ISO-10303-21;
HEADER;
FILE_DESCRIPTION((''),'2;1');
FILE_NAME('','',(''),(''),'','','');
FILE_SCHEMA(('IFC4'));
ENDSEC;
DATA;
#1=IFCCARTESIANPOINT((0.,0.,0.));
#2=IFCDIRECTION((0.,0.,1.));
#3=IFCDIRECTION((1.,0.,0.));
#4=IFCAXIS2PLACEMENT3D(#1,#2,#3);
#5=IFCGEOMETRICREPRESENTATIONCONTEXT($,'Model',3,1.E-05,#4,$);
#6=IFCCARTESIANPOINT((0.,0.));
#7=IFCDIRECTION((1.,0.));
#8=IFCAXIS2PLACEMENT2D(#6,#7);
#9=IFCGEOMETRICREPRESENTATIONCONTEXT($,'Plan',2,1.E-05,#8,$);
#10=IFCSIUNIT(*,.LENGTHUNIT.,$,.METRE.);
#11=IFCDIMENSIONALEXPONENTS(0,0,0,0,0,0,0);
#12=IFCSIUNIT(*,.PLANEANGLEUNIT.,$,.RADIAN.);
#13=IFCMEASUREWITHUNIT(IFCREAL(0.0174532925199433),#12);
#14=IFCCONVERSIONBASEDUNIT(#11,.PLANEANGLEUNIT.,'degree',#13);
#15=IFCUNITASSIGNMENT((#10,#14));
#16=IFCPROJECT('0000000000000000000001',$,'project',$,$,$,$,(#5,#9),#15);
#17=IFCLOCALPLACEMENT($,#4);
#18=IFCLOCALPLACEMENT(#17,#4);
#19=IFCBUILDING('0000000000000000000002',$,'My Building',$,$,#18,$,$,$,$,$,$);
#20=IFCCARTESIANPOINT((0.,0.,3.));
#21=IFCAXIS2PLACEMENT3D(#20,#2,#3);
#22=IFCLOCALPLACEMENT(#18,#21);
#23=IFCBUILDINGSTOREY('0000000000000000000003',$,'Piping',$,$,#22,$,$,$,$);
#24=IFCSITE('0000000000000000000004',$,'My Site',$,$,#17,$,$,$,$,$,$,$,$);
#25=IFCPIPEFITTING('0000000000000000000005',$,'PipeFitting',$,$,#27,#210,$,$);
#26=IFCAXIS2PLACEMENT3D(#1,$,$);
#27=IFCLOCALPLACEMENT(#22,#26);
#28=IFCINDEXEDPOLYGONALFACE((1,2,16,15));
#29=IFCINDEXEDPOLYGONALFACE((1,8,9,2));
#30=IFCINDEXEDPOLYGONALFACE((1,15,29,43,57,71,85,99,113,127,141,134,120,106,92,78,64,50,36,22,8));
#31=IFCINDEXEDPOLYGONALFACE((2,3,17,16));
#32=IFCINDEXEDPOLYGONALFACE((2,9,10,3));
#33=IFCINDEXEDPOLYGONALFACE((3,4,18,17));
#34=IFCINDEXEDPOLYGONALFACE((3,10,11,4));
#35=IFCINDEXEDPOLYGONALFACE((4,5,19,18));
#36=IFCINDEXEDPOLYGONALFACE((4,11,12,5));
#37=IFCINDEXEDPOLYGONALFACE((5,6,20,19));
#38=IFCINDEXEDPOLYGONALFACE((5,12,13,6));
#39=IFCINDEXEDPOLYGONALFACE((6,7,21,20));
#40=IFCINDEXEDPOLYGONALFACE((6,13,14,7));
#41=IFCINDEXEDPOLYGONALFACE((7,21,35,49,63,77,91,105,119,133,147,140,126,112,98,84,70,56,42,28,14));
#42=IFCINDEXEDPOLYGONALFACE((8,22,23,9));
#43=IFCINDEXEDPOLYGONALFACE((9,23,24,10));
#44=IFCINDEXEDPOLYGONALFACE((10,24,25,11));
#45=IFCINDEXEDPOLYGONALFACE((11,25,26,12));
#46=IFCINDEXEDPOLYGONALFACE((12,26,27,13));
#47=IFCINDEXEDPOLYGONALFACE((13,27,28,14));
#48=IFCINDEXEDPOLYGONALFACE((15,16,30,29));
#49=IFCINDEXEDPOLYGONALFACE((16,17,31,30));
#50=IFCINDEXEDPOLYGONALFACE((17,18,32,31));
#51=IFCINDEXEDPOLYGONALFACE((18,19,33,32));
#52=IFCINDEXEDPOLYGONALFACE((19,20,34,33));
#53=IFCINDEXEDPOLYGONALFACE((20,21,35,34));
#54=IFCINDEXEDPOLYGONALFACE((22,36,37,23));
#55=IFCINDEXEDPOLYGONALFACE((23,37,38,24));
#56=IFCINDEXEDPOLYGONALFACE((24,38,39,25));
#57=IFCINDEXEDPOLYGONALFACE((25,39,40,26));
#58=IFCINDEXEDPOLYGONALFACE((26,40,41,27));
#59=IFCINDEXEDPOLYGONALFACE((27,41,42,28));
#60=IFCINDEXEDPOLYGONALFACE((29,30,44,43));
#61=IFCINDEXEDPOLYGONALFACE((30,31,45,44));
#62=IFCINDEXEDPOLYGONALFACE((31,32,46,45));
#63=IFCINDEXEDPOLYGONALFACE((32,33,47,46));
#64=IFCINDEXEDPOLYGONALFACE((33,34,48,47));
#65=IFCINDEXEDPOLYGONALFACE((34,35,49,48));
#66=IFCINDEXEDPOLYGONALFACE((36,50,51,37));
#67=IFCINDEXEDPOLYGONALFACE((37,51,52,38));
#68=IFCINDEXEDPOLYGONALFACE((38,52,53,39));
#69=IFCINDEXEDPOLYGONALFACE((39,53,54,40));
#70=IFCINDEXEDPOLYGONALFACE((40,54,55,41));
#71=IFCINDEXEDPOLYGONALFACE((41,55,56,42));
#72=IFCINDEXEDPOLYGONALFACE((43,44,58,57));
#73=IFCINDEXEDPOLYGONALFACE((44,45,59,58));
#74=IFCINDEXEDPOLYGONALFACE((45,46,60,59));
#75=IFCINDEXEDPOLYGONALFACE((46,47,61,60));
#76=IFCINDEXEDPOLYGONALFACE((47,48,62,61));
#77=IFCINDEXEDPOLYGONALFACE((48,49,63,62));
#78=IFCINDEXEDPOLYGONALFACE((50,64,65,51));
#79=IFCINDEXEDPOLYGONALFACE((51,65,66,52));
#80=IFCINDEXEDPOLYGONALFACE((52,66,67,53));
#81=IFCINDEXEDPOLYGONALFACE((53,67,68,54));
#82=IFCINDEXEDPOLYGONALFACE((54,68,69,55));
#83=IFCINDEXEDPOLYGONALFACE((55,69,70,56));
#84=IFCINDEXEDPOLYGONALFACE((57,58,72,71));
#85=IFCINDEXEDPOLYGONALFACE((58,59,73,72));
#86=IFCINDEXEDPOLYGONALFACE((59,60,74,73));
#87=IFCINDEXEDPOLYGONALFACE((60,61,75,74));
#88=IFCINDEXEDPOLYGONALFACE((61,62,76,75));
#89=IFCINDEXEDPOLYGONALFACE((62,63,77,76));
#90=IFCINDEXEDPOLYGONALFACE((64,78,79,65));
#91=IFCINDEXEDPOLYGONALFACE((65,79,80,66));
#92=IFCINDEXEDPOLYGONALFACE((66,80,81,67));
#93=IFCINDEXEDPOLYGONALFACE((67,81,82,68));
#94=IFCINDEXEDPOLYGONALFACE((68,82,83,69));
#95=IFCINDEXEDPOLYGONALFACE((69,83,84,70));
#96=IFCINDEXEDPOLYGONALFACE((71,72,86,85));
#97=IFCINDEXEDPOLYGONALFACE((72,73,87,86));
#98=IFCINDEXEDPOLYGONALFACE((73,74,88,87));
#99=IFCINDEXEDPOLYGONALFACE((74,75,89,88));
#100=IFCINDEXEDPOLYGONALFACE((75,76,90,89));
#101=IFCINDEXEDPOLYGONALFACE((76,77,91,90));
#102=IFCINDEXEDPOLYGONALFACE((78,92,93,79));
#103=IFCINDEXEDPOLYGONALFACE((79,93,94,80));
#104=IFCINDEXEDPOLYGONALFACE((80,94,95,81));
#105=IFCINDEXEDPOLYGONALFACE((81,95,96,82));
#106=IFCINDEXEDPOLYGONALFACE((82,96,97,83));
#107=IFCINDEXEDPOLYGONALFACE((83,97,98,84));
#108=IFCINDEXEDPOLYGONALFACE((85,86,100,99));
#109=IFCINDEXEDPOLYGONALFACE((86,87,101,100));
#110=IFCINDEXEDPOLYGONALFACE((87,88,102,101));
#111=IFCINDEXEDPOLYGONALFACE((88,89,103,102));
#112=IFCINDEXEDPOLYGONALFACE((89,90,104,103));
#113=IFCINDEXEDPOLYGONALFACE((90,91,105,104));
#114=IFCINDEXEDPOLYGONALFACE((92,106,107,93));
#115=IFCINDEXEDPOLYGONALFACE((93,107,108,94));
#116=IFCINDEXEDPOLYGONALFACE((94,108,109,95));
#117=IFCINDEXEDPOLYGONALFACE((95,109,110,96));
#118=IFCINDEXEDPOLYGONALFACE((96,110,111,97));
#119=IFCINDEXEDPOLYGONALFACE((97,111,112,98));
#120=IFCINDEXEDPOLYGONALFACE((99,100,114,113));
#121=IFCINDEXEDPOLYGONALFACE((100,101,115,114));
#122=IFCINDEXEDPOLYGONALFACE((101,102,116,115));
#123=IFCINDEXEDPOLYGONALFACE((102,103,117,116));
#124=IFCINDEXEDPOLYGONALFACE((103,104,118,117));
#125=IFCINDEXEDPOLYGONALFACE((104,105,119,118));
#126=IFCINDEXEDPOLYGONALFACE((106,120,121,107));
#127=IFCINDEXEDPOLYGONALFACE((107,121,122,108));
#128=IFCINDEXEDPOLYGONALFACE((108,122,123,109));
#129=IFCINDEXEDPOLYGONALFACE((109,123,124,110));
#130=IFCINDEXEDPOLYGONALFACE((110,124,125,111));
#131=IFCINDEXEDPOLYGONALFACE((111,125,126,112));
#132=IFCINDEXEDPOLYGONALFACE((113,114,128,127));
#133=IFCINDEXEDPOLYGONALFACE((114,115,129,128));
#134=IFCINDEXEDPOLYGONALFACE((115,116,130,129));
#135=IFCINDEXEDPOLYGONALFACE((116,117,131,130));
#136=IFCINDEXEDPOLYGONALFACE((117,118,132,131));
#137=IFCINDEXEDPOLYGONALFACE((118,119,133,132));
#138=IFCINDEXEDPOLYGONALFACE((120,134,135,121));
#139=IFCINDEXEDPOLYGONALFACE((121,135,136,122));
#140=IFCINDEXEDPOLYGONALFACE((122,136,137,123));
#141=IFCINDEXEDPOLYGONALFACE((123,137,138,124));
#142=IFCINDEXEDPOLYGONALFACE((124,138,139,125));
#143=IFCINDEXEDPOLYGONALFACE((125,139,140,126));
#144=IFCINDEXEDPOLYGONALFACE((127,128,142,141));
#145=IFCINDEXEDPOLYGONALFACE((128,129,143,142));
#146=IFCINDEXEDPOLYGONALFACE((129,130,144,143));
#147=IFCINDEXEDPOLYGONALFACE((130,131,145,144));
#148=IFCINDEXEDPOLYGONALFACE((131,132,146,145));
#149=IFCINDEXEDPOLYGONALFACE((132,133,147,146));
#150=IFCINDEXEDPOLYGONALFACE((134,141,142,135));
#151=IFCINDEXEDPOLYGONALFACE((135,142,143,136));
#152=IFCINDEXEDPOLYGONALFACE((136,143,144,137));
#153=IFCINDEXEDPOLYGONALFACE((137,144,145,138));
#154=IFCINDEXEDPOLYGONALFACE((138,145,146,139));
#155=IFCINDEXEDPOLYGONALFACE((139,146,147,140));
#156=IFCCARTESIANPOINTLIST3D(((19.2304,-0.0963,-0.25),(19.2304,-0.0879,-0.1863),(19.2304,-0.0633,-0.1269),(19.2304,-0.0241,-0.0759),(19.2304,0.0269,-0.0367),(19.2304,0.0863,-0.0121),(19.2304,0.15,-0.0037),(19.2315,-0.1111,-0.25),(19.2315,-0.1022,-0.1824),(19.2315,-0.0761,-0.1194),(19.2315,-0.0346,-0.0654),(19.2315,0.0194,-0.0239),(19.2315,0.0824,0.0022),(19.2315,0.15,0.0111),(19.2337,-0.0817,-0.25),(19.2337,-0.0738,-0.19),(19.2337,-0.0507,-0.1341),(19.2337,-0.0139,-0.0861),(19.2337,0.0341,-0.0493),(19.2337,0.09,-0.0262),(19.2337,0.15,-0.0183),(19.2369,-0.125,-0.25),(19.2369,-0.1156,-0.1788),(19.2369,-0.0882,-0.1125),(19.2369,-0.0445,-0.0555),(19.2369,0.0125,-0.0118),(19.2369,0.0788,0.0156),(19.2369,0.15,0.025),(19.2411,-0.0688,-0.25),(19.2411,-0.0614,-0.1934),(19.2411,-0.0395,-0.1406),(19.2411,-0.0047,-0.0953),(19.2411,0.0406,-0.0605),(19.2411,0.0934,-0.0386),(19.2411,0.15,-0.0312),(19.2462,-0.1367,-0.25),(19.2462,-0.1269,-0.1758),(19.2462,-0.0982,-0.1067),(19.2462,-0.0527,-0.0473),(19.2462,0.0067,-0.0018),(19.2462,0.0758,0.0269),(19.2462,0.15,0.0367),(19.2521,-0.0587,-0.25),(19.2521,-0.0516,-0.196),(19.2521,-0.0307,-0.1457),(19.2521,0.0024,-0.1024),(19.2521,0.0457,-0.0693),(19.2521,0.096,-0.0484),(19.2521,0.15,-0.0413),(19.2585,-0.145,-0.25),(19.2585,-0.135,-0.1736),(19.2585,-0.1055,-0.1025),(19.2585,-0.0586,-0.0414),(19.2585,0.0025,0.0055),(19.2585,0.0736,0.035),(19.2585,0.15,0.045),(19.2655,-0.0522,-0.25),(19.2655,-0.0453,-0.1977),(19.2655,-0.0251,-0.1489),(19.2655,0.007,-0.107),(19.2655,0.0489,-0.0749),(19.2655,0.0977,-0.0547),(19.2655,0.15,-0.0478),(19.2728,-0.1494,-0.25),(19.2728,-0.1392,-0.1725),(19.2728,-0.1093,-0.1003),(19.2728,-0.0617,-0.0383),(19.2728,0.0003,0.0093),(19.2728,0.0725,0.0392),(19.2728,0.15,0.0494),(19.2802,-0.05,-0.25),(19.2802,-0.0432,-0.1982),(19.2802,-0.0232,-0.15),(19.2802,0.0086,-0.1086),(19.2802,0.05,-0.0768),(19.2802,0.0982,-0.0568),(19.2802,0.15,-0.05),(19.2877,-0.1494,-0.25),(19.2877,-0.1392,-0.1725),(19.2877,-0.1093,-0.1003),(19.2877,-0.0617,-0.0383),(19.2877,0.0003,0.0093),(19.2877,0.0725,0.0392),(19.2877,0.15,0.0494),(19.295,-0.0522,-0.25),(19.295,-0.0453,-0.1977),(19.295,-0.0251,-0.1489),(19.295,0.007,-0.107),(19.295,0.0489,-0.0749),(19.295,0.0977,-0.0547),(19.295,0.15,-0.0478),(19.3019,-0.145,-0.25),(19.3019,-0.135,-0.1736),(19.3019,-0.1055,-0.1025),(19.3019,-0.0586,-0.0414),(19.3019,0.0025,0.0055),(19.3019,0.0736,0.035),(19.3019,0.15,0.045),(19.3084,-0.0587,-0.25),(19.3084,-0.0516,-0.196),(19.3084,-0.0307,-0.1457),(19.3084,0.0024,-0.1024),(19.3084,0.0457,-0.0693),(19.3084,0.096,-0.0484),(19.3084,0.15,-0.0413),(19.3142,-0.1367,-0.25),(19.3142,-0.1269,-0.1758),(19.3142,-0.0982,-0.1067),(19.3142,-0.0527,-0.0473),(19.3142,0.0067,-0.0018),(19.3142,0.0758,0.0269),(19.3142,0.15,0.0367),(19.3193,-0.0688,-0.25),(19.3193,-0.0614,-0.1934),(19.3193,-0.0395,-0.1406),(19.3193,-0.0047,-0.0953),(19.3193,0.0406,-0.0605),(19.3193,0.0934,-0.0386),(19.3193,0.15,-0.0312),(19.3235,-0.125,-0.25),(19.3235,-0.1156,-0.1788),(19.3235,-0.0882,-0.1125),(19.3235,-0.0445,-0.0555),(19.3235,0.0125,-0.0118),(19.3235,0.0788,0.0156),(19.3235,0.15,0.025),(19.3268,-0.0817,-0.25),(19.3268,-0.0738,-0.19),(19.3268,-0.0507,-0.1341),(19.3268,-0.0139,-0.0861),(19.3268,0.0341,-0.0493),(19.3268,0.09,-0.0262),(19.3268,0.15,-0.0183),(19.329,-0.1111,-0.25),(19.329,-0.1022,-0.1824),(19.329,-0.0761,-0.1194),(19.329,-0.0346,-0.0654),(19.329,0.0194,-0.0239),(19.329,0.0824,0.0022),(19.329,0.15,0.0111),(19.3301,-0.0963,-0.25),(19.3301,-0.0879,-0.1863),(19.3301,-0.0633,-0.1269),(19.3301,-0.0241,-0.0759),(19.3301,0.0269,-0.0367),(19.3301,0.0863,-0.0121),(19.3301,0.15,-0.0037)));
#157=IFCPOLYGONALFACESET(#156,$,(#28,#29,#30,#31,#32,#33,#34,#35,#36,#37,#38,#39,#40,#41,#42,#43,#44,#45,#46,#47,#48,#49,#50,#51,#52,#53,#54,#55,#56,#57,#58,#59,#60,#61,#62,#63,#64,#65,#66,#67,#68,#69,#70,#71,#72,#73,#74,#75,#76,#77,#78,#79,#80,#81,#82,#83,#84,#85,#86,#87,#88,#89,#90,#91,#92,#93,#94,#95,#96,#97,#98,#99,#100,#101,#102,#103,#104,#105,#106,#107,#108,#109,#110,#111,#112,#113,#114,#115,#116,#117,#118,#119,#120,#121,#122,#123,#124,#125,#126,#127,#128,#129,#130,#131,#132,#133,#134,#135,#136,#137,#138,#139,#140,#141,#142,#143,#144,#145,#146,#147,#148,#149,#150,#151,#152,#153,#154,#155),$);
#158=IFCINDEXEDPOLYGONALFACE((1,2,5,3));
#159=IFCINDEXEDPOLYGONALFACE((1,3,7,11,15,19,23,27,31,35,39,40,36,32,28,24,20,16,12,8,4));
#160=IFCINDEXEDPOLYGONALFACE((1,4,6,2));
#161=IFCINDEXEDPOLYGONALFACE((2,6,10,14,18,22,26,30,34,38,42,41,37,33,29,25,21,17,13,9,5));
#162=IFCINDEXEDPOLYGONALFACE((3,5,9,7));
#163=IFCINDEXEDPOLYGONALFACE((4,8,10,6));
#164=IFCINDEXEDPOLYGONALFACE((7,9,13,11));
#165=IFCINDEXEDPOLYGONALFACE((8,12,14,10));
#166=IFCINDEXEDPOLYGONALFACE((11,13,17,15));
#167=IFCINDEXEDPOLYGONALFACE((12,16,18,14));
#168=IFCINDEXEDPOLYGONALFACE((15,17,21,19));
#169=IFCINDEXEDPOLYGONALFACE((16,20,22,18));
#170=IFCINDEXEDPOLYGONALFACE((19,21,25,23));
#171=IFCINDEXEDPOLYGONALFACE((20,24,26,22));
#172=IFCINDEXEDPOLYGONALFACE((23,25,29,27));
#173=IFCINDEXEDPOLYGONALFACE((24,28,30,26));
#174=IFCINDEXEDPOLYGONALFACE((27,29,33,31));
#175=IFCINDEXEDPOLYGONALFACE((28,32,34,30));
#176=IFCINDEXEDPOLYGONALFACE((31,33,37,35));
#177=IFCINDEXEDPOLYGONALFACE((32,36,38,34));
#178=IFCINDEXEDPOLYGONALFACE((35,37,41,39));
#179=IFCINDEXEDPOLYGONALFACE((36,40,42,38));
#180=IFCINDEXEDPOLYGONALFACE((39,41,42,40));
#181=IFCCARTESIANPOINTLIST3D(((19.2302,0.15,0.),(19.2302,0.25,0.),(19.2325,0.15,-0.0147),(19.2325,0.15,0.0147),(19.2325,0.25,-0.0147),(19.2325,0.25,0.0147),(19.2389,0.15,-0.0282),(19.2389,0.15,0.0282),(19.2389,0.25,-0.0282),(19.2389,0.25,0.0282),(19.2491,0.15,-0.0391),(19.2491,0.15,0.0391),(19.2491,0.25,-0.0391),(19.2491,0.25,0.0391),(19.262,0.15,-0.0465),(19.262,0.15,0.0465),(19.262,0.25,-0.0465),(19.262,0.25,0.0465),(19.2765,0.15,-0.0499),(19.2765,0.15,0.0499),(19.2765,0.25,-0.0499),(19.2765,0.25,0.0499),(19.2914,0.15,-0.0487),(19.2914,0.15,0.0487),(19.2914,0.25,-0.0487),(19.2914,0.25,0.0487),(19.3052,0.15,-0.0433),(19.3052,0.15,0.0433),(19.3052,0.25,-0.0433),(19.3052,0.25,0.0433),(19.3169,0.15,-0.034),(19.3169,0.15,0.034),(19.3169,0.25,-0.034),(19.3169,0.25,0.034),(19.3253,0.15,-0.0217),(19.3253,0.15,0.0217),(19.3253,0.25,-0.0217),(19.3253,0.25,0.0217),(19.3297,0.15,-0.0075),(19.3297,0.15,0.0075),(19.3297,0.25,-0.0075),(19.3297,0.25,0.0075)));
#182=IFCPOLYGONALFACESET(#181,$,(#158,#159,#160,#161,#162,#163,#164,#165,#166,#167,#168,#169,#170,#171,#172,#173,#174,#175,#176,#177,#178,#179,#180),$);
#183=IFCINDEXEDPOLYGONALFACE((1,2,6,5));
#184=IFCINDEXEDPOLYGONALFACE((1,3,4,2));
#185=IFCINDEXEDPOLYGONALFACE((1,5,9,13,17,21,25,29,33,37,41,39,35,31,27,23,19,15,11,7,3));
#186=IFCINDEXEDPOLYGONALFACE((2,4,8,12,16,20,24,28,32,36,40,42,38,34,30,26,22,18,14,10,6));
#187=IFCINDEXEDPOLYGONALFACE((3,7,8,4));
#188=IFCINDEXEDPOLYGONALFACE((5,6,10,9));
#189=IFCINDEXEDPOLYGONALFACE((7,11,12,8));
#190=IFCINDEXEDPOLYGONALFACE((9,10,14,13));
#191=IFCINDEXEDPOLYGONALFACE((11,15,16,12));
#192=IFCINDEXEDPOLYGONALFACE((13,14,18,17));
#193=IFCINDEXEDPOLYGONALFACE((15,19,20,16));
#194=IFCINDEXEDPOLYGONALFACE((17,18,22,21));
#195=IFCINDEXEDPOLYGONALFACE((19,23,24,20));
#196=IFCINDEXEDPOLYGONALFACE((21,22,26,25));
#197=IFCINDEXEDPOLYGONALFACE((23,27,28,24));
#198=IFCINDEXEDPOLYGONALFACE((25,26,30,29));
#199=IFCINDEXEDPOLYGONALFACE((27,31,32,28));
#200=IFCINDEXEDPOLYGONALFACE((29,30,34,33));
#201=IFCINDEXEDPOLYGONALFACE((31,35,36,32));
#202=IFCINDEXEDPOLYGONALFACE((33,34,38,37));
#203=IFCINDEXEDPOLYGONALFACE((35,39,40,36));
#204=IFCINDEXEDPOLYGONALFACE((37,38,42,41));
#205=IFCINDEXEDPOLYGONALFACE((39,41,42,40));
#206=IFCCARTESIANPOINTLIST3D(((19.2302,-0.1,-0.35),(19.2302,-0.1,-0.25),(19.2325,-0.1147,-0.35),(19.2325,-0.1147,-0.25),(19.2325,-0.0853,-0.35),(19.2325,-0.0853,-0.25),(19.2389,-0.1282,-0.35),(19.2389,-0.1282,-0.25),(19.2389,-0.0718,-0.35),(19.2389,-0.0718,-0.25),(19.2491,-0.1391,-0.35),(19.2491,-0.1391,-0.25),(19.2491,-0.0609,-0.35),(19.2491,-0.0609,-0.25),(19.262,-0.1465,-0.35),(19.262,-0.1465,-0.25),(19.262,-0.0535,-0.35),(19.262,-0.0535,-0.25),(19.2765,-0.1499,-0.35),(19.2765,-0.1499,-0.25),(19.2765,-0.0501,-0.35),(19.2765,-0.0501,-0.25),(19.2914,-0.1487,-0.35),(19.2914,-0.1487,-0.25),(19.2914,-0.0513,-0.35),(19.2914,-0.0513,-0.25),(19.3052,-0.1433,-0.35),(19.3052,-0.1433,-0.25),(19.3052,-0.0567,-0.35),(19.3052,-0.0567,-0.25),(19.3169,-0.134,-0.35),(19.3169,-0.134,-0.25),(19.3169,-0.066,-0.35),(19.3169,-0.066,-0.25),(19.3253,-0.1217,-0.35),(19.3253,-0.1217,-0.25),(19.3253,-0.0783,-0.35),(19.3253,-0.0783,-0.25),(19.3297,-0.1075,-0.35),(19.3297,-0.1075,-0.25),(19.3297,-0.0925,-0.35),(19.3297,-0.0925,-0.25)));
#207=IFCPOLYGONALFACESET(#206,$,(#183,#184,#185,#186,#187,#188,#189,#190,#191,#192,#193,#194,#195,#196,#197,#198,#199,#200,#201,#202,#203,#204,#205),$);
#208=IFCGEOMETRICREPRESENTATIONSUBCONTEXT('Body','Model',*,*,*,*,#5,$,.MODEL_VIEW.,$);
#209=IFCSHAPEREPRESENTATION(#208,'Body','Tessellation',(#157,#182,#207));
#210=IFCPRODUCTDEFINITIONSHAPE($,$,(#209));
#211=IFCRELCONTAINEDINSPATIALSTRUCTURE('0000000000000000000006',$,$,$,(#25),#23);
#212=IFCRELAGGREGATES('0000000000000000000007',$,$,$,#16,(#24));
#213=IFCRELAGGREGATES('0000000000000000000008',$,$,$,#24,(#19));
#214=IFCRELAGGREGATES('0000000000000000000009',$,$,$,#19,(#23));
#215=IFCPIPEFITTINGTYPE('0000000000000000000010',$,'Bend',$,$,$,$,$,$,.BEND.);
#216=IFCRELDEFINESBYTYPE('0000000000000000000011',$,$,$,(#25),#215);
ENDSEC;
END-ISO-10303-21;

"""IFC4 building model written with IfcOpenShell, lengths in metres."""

from ifc_helpers import new_model, entity, si_unit, converted_unit, frame, origin_with_axes, origin_2d_with_axis, place, context, subcontext, project, spatial, circle, extrude, source, transform, mapped, type_object, type_shapes, element, save


model = new_model("IFC4")

# Units and contexts
model_context = context("Model", 3, precision=1e-05, world=origin_with_axes())
plan_context = context("Plan", 2, precision=1e-05, world=origin_2d_with_axis())
body_context = subcontext(model_context, "Body", "Model", "MODEL_VIEW")
ifc_project = project(units=[si_unit("LENGTHUNIT", "METRE"), converted_unit("PLANEANGLEUNIT", "degree", entity("IfcReal", 0.0174532925199433), si_unit("PLANEANGLEUNIT", "RADIAN"), dimensions=[0, 0, 0, 0, 0, 0, 0])], contexts=[model_context, plan_context])

# Site, building, storey
site_placement = place(None, origin_with_axes())
site = spatial("IfcSite", under=ifc_project, at=site_placement, Name="My Site")
building_placement = place(site_placement, origin_with_axes())
building = spatial("IfcBuilding", under=site, at=building_placement, Name="My Building")
storey_placement = place(building_placement, frame((0.0, 0.0, 3.0), z_axis=(0.0, 0.0, 1.0), x_axis=(1.0, 0.0, 0.0)))
storey = spatial("IfcBuildingStorey", under=building, at=storey_placement, Name="Piping")

# Pipe fitting
pipe_fitting_type = type_object("IfcPipeFittingType", Name="Bend", PredefinedType="BEND")
shared_shape = source(origin_with_axes(), body_context, "Body", "SolidModel", [
    entity("IfcSweptDiskSolid", entity("IfcIndexedPolyCurve", entity("IfcCartesianPointList3D", [[0.0, 0.0, -0.1], [0.0, -0.0732, -0.2768], [0.0, -0.25, -0.35]]), [entity("IfcArcIndex", [1, 2, 3])]), 0.05),
    extrude(circle(Radius=0.05), origin_with_axes(), (0.0, 0.0, -1.0), 0.1),
    extrude(circle(Radius=0.05), frame((0.0, -0.25, -0.35), z_axis=(0.0, -1.0, 0.0), x_axis=(1.0, 0.0, 0.0)), (0.0, 0.0, 1.0), 0.1),
])
type_shapes(pipe_fitting_type, [shared_shape])
for number, where, z_axis, x_axis, name in (
    (1, (19.2802, 0.25, 0.0), (0.0, 1.0, 0.0), (-1.0, 0.0, 0.0), "PipeFitting"),
):
    element("IfcPipeFitting", number, at=place(storey_placement, frame(where, z_axis=z_axis, x_axis=x_axis)), inside=storey, type_object=pipe_fitting_type, Name=name, context=body_context, shape_type="MappedRepresentation", body=[
        mapped(shared_shape, transform((0.0, 0.0, 0.0), x_axis=(1.0, 0.0, 0.0), y_axis=(0.0, 1.0, 0.0), z_axis=(0.0, 0.0, 1.0), scale=1.0)),
    ])

save(model, "model.ifc")
